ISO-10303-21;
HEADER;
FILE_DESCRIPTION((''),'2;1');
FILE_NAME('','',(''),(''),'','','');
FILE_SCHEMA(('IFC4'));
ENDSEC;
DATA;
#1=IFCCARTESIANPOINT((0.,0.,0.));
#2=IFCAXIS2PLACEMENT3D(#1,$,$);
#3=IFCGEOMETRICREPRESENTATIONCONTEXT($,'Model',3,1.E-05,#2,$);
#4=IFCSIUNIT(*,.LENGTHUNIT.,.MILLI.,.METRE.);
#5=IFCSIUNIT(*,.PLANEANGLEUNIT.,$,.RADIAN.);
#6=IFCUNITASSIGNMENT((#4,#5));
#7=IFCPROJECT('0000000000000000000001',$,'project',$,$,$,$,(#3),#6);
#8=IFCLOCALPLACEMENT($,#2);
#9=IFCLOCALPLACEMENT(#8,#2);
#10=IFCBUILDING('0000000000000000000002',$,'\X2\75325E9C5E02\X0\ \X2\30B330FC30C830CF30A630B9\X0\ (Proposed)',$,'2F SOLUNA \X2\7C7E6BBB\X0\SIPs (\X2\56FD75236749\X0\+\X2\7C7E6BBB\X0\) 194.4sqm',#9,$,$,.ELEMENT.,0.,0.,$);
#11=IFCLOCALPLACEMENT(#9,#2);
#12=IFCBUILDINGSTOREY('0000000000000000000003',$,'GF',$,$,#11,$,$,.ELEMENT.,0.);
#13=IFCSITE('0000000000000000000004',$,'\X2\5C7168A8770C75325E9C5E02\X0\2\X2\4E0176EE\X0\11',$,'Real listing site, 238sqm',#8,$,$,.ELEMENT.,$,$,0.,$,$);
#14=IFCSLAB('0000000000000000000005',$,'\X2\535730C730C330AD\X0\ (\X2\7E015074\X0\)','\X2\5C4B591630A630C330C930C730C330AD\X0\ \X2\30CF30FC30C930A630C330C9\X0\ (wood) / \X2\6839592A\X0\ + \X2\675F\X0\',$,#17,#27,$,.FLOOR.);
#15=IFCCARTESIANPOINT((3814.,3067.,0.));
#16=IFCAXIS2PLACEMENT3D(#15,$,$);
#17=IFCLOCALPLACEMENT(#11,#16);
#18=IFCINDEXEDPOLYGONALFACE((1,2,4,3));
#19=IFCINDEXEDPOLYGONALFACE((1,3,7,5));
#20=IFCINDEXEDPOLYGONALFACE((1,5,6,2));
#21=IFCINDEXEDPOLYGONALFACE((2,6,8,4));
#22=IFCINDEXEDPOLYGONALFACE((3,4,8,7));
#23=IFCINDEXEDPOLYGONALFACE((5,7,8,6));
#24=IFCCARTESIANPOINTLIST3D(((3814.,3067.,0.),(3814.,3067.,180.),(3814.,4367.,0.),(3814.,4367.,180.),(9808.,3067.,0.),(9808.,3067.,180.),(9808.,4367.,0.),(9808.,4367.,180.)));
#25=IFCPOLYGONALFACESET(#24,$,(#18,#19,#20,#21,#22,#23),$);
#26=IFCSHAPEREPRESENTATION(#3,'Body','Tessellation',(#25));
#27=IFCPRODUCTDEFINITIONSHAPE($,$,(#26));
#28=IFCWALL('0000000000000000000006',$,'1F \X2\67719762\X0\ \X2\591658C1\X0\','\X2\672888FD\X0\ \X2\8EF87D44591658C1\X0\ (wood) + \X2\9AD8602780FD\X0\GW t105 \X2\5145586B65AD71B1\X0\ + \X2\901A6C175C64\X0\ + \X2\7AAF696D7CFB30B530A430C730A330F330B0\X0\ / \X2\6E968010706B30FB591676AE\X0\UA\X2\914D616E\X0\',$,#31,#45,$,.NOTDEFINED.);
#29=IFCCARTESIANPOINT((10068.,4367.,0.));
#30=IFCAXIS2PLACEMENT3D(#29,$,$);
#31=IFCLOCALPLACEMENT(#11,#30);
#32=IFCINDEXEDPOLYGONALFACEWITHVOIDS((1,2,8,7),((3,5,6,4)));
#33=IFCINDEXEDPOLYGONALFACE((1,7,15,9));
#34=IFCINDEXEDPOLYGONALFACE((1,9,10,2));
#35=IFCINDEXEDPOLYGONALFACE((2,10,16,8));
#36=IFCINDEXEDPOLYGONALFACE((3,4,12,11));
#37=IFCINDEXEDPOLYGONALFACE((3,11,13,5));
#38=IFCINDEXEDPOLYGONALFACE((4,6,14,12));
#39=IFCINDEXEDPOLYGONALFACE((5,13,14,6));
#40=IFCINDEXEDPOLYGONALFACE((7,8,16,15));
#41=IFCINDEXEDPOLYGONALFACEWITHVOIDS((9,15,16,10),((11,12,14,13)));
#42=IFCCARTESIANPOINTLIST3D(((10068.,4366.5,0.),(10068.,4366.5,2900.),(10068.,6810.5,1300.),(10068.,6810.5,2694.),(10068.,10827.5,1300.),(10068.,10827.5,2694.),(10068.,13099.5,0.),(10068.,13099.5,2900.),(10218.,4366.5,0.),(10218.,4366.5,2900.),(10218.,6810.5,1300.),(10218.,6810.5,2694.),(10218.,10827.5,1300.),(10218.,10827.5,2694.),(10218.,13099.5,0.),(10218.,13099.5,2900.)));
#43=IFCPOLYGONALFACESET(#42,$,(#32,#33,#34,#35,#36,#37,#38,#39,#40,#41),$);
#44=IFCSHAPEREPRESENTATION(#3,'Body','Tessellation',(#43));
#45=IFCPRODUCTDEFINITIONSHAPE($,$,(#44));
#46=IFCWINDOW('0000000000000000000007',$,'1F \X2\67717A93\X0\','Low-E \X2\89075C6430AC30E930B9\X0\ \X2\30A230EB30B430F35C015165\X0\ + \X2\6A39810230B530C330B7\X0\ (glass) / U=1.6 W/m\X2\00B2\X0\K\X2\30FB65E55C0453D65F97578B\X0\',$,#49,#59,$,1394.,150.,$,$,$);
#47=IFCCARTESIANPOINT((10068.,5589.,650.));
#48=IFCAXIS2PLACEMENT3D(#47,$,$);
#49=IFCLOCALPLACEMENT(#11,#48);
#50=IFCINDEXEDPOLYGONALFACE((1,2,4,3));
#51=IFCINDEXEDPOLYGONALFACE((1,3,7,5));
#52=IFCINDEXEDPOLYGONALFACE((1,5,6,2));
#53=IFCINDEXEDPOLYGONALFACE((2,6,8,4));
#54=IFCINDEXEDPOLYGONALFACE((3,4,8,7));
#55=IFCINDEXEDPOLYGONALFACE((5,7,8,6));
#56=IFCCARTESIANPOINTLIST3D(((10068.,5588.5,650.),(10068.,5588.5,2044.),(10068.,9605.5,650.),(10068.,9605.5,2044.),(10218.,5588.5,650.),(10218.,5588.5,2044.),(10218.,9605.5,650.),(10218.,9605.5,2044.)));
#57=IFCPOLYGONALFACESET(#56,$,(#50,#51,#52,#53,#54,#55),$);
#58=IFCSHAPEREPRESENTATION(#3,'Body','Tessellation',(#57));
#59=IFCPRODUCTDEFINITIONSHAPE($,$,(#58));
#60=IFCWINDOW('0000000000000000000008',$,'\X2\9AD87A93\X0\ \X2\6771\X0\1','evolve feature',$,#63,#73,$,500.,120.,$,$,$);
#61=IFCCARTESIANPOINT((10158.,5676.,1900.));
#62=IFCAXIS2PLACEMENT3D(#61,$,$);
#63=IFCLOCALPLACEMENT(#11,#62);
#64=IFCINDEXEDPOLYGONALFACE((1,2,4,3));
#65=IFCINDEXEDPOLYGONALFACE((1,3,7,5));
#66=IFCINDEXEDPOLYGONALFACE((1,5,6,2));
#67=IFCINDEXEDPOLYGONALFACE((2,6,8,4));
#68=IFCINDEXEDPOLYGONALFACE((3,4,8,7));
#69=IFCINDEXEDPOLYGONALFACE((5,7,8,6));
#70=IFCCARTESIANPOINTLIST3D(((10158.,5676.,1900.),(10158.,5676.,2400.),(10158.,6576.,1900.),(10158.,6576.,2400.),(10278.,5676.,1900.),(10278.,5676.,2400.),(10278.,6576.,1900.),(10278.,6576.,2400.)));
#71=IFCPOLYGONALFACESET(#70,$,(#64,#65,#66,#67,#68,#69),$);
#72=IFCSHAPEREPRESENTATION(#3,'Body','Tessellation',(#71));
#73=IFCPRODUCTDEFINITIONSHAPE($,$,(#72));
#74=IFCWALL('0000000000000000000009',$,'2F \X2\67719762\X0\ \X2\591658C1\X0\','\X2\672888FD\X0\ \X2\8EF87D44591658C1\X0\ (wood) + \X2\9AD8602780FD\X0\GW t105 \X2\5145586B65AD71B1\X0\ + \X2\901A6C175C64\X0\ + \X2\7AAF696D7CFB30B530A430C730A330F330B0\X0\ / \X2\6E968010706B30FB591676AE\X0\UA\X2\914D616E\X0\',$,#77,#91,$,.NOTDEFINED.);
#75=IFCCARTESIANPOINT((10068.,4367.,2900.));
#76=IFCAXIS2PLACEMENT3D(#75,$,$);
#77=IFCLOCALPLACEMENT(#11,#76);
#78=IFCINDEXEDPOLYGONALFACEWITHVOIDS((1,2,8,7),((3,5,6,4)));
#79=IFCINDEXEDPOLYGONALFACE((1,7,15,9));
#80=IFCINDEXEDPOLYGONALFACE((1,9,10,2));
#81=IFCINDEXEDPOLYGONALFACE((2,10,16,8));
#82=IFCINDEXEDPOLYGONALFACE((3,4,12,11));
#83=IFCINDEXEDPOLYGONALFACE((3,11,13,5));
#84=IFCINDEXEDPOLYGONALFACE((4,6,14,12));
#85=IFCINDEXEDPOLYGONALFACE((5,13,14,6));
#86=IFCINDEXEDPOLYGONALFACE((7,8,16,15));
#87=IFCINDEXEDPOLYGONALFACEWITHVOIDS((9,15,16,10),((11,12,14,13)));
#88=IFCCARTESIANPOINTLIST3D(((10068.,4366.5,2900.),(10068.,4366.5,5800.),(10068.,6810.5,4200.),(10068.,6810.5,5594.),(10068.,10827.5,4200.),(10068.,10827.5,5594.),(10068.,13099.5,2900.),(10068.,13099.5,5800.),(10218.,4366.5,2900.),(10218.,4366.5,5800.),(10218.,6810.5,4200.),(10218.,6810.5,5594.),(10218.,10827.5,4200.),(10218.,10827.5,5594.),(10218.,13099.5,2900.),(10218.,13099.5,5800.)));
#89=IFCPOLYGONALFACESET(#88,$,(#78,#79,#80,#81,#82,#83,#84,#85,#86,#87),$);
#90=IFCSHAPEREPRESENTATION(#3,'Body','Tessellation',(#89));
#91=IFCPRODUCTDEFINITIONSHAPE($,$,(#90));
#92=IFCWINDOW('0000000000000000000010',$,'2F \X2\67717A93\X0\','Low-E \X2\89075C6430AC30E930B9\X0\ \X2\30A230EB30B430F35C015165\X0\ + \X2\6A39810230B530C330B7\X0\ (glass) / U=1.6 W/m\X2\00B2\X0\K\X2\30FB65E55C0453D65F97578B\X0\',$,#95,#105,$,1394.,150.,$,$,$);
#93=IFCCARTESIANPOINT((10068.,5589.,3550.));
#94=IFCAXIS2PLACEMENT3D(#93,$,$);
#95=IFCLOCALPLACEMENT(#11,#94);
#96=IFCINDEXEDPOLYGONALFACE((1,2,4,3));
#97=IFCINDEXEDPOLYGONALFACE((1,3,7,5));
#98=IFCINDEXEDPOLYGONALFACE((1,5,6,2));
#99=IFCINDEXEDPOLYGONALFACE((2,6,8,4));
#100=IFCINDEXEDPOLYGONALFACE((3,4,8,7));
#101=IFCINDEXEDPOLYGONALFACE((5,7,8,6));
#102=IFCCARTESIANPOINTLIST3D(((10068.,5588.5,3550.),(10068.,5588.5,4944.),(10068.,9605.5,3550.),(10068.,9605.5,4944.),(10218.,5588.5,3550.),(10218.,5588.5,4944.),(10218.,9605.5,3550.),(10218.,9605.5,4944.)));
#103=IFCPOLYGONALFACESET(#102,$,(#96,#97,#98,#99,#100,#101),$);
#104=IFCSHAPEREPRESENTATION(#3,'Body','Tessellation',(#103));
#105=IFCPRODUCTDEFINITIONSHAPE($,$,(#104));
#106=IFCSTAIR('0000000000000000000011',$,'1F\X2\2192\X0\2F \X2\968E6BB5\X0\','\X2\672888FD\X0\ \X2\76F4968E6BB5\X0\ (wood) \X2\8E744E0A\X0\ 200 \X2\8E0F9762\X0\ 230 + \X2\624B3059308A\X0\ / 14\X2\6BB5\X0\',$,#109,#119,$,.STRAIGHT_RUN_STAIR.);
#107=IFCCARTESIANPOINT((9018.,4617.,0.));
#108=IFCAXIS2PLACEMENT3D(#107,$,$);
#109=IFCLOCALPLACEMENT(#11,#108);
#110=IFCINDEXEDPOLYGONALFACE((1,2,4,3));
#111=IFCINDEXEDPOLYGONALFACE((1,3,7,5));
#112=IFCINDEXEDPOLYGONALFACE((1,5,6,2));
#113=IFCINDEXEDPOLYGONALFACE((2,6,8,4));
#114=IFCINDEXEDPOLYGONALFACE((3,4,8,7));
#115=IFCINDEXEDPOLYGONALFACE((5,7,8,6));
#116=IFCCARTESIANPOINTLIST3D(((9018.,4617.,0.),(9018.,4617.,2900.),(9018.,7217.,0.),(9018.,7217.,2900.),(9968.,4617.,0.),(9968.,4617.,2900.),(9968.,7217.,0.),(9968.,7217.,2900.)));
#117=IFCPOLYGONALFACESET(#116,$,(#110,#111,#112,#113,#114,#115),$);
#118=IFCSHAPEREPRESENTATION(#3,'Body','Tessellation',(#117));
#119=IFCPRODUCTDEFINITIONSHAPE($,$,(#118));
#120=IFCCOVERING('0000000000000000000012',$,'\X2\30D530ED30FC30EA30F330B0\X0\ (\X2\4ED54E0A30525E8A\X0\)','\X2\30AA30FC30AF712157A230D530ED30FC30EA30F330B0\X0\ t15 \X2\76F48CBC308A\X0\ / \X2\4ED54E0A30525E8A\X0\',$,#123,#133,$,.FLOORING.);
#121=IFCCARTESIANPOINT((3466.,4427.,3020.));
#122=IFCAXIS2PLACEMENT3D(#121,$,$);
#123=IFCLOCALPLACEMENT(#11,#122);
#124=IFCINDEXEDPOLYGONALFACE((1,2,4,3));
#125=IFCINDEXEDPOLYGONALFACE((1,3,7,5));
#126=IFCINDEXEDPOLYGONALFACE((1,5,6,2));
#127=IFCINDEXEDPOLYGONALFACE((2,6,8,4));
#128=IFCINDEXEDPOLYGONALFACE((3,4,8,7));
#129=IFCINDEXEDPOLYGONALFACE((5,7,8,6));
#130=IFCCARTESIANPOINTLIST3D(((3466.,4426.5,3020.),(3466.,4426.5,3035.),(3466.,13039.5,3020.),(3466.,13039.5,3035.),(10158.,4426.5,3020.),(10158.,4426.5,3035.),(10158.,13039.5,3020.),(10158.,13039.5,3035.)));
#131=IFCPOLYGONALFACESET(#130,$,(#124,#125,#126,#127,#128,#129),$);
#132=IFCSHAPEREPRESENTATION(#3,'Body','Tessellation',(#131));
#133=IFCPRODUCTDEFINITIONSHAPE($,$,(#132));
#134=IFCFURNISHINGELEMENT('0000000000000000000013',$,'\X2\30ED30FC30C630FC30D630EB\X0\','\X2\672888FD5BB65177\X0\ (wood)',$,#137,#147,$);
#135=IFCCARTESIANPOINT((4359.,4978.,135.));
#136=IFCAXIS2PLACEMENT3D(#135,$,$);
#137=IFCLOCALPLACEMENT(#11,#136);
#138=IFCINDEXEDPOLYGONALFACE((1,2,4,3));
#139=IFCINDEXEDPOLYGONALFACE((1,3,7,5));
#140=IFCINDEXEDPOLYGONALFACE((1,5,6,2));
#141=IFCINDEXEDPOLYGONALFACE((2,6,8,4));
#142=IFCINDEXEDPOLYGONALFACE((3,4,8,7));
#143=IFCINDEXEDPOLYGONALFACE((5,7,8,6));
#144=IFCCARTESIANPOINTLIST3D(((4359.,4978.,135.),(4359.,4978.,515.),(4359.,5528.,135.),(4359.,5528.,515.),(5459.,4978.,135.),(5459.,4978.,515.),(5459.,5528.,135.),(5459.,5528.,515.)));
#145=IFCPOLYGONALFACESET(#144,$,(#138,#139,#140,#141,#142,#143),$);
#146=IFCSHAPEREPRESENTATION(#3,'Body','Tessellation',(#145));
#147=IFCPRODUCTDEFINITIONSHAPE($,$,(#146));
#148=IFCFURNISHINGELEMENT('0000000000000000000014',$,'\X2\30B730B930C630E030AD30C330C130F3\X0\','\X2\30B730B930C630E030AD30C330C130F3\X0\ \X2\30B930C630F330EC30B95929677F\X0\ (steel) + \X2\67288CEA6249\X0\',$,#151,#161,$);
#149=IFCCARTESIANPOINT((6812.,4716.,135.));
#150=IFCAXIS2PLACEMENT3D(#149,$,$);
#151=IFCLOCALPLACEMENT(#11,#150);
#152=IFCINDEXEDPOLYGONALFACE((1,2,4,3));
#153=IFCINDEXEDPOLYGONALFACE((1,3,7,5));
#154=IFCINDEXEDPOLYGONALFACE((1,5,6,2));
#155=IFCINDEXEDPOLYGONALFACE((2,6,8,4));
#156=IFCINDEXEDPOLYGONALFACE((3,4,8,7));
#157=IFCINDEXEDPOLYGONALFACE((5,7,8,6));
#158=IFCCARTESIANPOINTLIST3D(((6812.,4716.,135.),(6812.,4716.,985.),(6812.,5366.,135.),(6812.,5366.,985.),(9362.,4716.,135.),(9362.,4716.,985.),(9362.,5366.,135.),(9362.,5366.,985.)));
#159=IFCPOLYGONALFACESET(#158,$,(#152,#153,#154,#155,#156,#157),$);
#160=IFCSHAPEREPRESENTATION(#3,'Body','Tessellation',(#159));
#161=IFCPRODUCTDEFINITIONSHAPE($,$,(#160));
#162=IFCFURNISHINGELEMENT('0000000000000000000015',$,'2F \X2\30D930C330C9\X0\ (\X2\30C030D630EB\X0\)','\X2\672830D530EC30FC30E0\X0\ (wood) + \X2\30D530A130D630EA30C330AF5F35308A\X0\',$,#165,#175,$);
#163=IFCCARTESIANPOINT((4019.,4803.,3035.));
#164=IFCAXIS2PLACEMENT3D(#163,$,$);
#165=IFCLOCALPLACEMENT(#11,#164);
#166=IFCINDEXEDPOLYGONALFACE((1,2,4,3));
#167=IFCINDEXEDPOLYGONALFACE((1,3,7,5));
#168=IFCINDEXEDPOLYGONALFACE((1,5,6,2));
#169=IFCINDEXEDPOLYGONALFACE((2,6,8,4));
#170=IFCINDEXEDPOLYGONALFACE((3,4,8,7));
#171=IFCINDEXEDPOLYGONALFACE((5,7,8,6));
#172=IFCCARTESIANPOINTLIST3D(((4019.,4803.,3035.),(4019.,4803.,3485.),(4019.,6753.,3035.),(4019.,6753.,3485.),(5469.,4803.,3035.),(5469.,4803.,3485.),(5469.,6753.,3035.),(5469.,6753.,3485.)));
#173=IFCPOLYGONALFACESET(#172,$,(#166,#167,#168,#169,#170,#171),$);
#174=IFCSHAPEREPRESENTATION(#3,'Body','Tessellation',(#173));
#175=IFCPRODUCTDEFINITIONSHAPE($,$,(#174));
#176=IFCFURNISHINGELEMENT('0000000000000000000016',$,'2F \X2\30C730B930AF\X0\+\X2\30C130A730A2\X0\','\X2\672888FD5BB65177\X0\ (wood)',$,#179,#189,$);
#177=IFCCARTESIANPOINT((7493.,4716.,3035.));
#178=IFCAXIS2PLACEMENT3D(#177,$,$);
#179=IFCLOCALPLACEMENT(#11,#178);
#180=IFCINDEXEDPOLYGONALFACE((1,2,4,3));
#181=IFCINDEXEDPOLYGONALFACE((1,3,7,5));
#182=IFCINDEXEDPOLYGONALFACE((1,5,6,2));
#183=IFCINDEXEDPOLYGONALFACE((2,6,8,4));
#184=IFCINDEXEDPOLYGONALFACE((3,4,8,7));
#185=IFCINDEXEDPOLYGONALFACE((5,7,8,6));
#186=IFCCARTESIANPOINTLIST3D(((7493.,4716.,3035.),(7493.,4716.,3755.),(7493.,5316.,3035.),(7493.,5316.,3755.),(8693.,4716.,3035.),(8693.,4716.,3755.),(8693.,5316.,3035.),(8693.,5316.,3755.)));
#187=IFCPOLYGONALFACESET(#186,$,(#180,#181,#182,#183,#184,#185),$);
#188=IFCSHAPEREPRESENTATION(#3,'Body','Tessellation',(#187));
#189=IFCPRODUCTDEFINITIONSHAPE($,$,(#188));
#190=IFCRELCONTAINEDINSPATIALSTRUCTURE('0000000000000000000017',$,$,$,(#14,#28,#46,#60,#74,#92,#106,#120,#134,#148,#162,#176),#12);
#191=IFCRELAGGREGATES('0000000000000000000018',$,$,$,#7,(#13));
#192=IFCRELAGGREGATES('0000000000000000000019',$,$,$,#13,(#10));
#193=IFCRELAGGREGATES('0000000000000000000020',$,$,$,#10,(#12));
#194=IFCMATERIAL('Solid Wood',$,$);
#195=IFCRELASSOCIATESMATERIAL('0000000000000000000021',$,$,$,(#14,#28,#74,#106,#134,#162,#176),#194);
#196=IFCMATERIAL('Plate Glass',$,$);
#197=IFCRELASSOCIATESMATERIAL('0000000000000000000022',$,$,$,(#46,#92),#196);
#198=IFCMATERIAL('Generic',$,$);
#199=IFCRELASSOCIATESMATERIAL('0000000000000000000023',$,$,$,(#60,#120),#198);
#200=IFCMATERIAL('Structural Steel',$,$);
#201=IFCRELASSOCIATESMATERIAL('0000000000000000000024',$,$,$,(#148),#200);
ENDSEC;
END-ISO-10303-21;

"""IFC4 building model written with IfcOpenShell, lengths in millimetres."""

from ifc_helpers import new_model, si_unit, frame, frame_2d, origin, place, context, project, spatial, rectangle, extrude, material, element, fill, save


model = new_model("IFC4")

# Units and contexts
model_context = context("Model", 3, precision=1e-05, world=origin())
ifc_project = project(units=[si_unit("LENGTHUNIT", "METRE", prefix="MILLI"), si_unit("PLANEANGLEUNIT", "RADIAN")], contexts=[model_context])

# Site, building, storey
site_placement = place(None, origin())
site = spatial("IfcSite", under=ifc_project, at=site_placement, Name="山梨県甲府市2丁目11", ObjectType="Real listing site, 238sqm", CompositionType="ELEMENT", RefElevation=0.0)
building_placement = place(site_placement, origin())
building = spatial("IfcBuilding", under=site, at=building_placement, Name="甲府市 コートハウス (Proposed)", ObjectType="2F SOLUNA 籾殻SIPs (国産杉+籾殻) 194.4sqm", CompositionType="ELEMENT", ElevationOfRefHeight=0.0, ElevationOfTerrain=0.0)
storey_placement = place(building_placement, origin())
storey = spatial("IfcBuildingStorey", under=building, at=storey_placement, Name="GF", CompositionType="ELEMENT", Elevation=0.0)

# Slab
ifc_material_1 = material(Name="Solid Wood")
slab_placement = place(storey_placement, frame((3814.0, 3067.0, 0.0)))
element("IfcSlab", 1, at=slab_placement, inside=storey, material=ifc_material_1, Name="南デッキ (縁側)", Description="屋外ウッドデッキ ハードウッド (wood) / 根太 + 束", PredefinedType="FLOOR", context=model_context, shape_type="SweptSolid", body=[
    extrude(rectangle(XDim=5994.0, YDim=1300.0, at=frame_2d((2997.0, 650.0))), frame((3814.0, 3067.0, 0.0)), (0.0, 0.0, 1.0), 180.0),
])

# Wall, openings, windows
wall_1_placement = place(storey_placement, frame((10068.0, 4367.0, 0.0)))
wall_1 = element("IfcWall", 2, at=wall_1_placement, inside=storey, material=ifc_material_1, Name="1F 東面 外壁", Description="木製 軸組外壁 (wood) + 高性能GW t105 充填断熱 + 通気層 + 窯業系サイディング / 準耐火・外皮UA配慮", PredefinedType="NOTDEFINED", context=model_context, shape_type="SweptSolid", body=[
    extrude(rectangle(XDim=150.0, YDim=8733.0, at=frame_2d((75.0, 4366.0))), frame((10068.0, 4367.0, 0.0)), (0.0, 0.0, 1.0), 2900.0),
])
opening_1_placement = place(storey_placement, frame((10068.0, 5589.0, 650.0)))
opening_1 = element("IfcOpeningElement", 3, at=opening_1_placement, cuts=wall_1, PredefinedType="NOTDEFINED", context=model_context, shape_type="SweptSolid", body=[
    extrude(rectangle(XDim=150.0, YDim=4017.0, at=frame_2d((75.0, 2008.0))), frame((10068.0, 5589.0, 650.0)), (0.0, 0.0, 1.0), 1394.0),
])
opening_2_placement = place(storey_placement, frame((10158.0, 5676.0, 1900.0)))
opening_2 = element("IfcOpeningElement", 4, at=opening_2_placement, cuts=wall_1, PredefinedType="NOTDEFINED", context=model_context, shape_type="SweptSolid", body=[
    extrude(rectangle(XDim=120.0, YDim=900.0, at=frame_2d((60.0, 450.0))), frame((10158.0, 5676.0, 1900.0)), (0.0, 0.0, 1.0), 500.0),
])
ifc_material_2 = material(Name="Plate Glass")
window_1_placement = place(storey_placement, frame((10068.0, 5589.0, 650.0)))
window_1 = element("IfcWindow", 5, at=window_1_placement, inside=storey, material=ifc_material_2, Name="1F 東窓", Description="Low-E 複層ガラス アルゴン封入 + 樹脂サッシ (glass) / U=1.6 W/m²K・日射取得型", OverallHeight=1394.0, OverallWidth=150.0, context=model_context, shape_type="SweptSolid", body=[
    extrude(rectangle(XDim=150.0, YDim=4017.0, at=frame_2d((75.0, 2008.0))), frame((10068.0, 5589.0, 650.0)), (0.0, 0.0, 1.0), 1394.0),
])
fill(opening_1, window_1)
ifc_material_3 = material(Name="Generic")
window_2_placement = place(storey_placement, frame((10158.0, 5676.0, 1900.0)))
window_2 = element("IfcWindow", 6, at=window_2_placement, inside=storey, material=ifc_material_3, Name="高窓 東1", Description="evolve feature", OverallHeight=500.0, OverallWidth=120.0, context=model_context, shape_type="SweptSolid", body=[
    extrude(rectangle(XDim=120.0, YDim=900.0, at=frame_2d((60.0, 450.0))), frame((10158.0, 5676.0, 1900.0)), (0.0, 0.0, 1.0), 500.0),
])
fill(opening_2, window_2)

# Wall, opening, window
wall_2_placement = place(storey_placement, frame((10068.0, 4367.0, 2900.0)))
wall_2 = element("IfcWall", 7, at=wall_2_placement, inside=storey, material=ifc_material_1, Name="2F 東面 外壁", Description="木製 軸組外壁 (wood) + 高性能GW t105 充填断熱 + 通気層 + 窯業系サイディング / 準耐火・外皮UA配慮", PredefinedType="NOTDEFINED", context=model_context, shape_type="SweptSolid", body=[
    extrude(rectangle(XDim=150.0, YDim=8733.0, at=frame_2d((75.0, 4366.0))), frame((10068.0, 4367.0, 2900.0)), (0.0, 0.0, 1.0), 2900.0),
])
opening_3_placement = place(storey_placement, frame((10068.0, 5589.0, 3550.0)))
opening_3 = element("IfcOpeningElement", 8, at=opening_3_placement, cuts=wall_2, PredefinedType="NOTDEFINED", context=model_context, shape_type="SweptSolid", body=[
    extrude(rectangle(XDim=150.0, YDim=4017.0, at=frame_2d((75.0, 2008.0))), frame((10068.0, 5589.0, 3550.0)), (0.0, 0.0, 1.0), 1394.0),
])
window_3_placement = place(storey_placement, frame((10068.0, 5589.0, 3550.0)))
window_3 = element("IfcWindow", 9, at=window_3_placement, inside=storey, material=ifc_material_2, Name="2F 東窓", Description="Low-E 複層ガラス アルゴン封入 + 樹脂サッシ (glass) / U=1.6 W/m²K・日射取得型", OverallHeight=1394.0, OverallWidth=150.0, context=model_context, shape_type="SweptSolid", body=[
    extrude(rectangle(XDim=150.0, YDim=4017.0, at=frame_2d((75.0, 2008.0))), frame((10068.0, 5589.0, 3550.0)), (0.0, 0.0, 1.0), 1394.0),
])
fill(opening_3, window_3)

# Stair
stair_placement = place(storey_placement, frame((9018.0, 4617.0, 0.0)))
element("IfcStair", 10, at=stair_placement, inside=storey, material=ifc_material_1, Name="1F→2F 階段", Description="木製 直階段 (wood) 蹴上 200 踏面 230 + 手すり / 14段", PredefinedType="STRAIGHT_RUN_STAIR", context=model_context, shape_type="SweptSolid", body=[
    extrude(rectangle(XDim=950.0, YDim=2600.0, at=frame_2d((475.0, 1300.0))), frame((9018.0, 4617.0, 0.0)), (0.0, 0.0, 1.0), 2900.0),
])

# Covering
covering_placement = place(storey_placement, frame((3466.0, 4427.0, 3020.0)))
element("IfcCovering", 11, at=covering_placement, inside=storey, material=ifc_material_3, Name="フローリング (仕上げ床)", Description="オーク無垢フローリング t15 直貼り / 仕上げ床", PredefinedType="FLOORING", context=model_context, shape_type="SweptSolid", body=[
    extrude(rectangle(XDim=6692.0, YDim=8613.0, at=frame_2d((3346.0, 4306.0))), frame((3466.0, 4427.0, 3020.0)), (0.0, 0.0, 1.0), 15.0),
])

# Furnishing elements
furnishing_1_placement = place(storey_placement, frame((4359.0, 4978.0, 135.0)))
element("IfcFurnishingElement", 12, at=furnishing_1_placement, inside=storey, material=ifc_material_1, Name="ローテーブル", Description="木製家具 (wood)", context=model_context, shape_type="SweptSolid", body=[
    extrude(rectangle(XDim=1100.0, YDim=550.0, at=frame_2d((550.0, 275.0))), frame((4359.0, 4978.0, 135.0)), (0.0, 0.0, 1.0), 380.0),
])
ifc_material_4 = material(Name="Structural Steel")
furnishing_2_placement = place(storey_placement, frame((6812.0, 4716.0, 135.0)))
element("IfcFurnishingElement", 13, at=furnishing_2_placement, inside=storey, material=ifc_material_4, Name="システムキッチン", Description="システムキッチン ステンレス天板 (steel) + 木質扉", context=model_context, shape_type="SweptSolid", body=[
    extrude(rectangle(XDim=2550.0, YDim=650.0, at=frame_2d((1275.0, 325.0))), frame((6812.0, 4716.0, 135.0)), (0.0, 0.0, 1.0), 850.0),
])
furnishing_3_placement = place(storey_placement, frame((4019.0, 4803.0, 3035.0)))
element("IfcFurnishingElement", 14, at=furnishing_3_placement, inside=storey, material=ifc_material_1, Name="2F ベッド (ダブル)", Description="木フレーム (wood) + ファブリック張り", context=model_context, shape_type="SweptSolid", body=[
    extrude(rectangle(XDim=1450.0, YDim=1950.0, at=frame_2d((725.0, 975.0))), frame((4019.0, 4803.0, 3035.0)), (0.0, 0.0, 1.0), 450.0),
])
furnishing_4_placement = place(storey_placement, frame((7493.0, 4716.0, 3035.0)))
element("IfcFurnishingElement", 15, at=furnishing_4_placement, inside=storey, material=ifc_material_1, Name="2F デスク+チェア", Description="木製家具 (wood)", context=model_context, shape_type="SweptSolid", body=[
    extrude(rectangle(XDim=1200.0, YDim=600.0, at=frame_2d((600.0, 300.0))), frame((7493.0, 4716.0, 3035.0)), (0.0, 0.0, 1.0), 720.0),
])

save(model, "model.ifc")
